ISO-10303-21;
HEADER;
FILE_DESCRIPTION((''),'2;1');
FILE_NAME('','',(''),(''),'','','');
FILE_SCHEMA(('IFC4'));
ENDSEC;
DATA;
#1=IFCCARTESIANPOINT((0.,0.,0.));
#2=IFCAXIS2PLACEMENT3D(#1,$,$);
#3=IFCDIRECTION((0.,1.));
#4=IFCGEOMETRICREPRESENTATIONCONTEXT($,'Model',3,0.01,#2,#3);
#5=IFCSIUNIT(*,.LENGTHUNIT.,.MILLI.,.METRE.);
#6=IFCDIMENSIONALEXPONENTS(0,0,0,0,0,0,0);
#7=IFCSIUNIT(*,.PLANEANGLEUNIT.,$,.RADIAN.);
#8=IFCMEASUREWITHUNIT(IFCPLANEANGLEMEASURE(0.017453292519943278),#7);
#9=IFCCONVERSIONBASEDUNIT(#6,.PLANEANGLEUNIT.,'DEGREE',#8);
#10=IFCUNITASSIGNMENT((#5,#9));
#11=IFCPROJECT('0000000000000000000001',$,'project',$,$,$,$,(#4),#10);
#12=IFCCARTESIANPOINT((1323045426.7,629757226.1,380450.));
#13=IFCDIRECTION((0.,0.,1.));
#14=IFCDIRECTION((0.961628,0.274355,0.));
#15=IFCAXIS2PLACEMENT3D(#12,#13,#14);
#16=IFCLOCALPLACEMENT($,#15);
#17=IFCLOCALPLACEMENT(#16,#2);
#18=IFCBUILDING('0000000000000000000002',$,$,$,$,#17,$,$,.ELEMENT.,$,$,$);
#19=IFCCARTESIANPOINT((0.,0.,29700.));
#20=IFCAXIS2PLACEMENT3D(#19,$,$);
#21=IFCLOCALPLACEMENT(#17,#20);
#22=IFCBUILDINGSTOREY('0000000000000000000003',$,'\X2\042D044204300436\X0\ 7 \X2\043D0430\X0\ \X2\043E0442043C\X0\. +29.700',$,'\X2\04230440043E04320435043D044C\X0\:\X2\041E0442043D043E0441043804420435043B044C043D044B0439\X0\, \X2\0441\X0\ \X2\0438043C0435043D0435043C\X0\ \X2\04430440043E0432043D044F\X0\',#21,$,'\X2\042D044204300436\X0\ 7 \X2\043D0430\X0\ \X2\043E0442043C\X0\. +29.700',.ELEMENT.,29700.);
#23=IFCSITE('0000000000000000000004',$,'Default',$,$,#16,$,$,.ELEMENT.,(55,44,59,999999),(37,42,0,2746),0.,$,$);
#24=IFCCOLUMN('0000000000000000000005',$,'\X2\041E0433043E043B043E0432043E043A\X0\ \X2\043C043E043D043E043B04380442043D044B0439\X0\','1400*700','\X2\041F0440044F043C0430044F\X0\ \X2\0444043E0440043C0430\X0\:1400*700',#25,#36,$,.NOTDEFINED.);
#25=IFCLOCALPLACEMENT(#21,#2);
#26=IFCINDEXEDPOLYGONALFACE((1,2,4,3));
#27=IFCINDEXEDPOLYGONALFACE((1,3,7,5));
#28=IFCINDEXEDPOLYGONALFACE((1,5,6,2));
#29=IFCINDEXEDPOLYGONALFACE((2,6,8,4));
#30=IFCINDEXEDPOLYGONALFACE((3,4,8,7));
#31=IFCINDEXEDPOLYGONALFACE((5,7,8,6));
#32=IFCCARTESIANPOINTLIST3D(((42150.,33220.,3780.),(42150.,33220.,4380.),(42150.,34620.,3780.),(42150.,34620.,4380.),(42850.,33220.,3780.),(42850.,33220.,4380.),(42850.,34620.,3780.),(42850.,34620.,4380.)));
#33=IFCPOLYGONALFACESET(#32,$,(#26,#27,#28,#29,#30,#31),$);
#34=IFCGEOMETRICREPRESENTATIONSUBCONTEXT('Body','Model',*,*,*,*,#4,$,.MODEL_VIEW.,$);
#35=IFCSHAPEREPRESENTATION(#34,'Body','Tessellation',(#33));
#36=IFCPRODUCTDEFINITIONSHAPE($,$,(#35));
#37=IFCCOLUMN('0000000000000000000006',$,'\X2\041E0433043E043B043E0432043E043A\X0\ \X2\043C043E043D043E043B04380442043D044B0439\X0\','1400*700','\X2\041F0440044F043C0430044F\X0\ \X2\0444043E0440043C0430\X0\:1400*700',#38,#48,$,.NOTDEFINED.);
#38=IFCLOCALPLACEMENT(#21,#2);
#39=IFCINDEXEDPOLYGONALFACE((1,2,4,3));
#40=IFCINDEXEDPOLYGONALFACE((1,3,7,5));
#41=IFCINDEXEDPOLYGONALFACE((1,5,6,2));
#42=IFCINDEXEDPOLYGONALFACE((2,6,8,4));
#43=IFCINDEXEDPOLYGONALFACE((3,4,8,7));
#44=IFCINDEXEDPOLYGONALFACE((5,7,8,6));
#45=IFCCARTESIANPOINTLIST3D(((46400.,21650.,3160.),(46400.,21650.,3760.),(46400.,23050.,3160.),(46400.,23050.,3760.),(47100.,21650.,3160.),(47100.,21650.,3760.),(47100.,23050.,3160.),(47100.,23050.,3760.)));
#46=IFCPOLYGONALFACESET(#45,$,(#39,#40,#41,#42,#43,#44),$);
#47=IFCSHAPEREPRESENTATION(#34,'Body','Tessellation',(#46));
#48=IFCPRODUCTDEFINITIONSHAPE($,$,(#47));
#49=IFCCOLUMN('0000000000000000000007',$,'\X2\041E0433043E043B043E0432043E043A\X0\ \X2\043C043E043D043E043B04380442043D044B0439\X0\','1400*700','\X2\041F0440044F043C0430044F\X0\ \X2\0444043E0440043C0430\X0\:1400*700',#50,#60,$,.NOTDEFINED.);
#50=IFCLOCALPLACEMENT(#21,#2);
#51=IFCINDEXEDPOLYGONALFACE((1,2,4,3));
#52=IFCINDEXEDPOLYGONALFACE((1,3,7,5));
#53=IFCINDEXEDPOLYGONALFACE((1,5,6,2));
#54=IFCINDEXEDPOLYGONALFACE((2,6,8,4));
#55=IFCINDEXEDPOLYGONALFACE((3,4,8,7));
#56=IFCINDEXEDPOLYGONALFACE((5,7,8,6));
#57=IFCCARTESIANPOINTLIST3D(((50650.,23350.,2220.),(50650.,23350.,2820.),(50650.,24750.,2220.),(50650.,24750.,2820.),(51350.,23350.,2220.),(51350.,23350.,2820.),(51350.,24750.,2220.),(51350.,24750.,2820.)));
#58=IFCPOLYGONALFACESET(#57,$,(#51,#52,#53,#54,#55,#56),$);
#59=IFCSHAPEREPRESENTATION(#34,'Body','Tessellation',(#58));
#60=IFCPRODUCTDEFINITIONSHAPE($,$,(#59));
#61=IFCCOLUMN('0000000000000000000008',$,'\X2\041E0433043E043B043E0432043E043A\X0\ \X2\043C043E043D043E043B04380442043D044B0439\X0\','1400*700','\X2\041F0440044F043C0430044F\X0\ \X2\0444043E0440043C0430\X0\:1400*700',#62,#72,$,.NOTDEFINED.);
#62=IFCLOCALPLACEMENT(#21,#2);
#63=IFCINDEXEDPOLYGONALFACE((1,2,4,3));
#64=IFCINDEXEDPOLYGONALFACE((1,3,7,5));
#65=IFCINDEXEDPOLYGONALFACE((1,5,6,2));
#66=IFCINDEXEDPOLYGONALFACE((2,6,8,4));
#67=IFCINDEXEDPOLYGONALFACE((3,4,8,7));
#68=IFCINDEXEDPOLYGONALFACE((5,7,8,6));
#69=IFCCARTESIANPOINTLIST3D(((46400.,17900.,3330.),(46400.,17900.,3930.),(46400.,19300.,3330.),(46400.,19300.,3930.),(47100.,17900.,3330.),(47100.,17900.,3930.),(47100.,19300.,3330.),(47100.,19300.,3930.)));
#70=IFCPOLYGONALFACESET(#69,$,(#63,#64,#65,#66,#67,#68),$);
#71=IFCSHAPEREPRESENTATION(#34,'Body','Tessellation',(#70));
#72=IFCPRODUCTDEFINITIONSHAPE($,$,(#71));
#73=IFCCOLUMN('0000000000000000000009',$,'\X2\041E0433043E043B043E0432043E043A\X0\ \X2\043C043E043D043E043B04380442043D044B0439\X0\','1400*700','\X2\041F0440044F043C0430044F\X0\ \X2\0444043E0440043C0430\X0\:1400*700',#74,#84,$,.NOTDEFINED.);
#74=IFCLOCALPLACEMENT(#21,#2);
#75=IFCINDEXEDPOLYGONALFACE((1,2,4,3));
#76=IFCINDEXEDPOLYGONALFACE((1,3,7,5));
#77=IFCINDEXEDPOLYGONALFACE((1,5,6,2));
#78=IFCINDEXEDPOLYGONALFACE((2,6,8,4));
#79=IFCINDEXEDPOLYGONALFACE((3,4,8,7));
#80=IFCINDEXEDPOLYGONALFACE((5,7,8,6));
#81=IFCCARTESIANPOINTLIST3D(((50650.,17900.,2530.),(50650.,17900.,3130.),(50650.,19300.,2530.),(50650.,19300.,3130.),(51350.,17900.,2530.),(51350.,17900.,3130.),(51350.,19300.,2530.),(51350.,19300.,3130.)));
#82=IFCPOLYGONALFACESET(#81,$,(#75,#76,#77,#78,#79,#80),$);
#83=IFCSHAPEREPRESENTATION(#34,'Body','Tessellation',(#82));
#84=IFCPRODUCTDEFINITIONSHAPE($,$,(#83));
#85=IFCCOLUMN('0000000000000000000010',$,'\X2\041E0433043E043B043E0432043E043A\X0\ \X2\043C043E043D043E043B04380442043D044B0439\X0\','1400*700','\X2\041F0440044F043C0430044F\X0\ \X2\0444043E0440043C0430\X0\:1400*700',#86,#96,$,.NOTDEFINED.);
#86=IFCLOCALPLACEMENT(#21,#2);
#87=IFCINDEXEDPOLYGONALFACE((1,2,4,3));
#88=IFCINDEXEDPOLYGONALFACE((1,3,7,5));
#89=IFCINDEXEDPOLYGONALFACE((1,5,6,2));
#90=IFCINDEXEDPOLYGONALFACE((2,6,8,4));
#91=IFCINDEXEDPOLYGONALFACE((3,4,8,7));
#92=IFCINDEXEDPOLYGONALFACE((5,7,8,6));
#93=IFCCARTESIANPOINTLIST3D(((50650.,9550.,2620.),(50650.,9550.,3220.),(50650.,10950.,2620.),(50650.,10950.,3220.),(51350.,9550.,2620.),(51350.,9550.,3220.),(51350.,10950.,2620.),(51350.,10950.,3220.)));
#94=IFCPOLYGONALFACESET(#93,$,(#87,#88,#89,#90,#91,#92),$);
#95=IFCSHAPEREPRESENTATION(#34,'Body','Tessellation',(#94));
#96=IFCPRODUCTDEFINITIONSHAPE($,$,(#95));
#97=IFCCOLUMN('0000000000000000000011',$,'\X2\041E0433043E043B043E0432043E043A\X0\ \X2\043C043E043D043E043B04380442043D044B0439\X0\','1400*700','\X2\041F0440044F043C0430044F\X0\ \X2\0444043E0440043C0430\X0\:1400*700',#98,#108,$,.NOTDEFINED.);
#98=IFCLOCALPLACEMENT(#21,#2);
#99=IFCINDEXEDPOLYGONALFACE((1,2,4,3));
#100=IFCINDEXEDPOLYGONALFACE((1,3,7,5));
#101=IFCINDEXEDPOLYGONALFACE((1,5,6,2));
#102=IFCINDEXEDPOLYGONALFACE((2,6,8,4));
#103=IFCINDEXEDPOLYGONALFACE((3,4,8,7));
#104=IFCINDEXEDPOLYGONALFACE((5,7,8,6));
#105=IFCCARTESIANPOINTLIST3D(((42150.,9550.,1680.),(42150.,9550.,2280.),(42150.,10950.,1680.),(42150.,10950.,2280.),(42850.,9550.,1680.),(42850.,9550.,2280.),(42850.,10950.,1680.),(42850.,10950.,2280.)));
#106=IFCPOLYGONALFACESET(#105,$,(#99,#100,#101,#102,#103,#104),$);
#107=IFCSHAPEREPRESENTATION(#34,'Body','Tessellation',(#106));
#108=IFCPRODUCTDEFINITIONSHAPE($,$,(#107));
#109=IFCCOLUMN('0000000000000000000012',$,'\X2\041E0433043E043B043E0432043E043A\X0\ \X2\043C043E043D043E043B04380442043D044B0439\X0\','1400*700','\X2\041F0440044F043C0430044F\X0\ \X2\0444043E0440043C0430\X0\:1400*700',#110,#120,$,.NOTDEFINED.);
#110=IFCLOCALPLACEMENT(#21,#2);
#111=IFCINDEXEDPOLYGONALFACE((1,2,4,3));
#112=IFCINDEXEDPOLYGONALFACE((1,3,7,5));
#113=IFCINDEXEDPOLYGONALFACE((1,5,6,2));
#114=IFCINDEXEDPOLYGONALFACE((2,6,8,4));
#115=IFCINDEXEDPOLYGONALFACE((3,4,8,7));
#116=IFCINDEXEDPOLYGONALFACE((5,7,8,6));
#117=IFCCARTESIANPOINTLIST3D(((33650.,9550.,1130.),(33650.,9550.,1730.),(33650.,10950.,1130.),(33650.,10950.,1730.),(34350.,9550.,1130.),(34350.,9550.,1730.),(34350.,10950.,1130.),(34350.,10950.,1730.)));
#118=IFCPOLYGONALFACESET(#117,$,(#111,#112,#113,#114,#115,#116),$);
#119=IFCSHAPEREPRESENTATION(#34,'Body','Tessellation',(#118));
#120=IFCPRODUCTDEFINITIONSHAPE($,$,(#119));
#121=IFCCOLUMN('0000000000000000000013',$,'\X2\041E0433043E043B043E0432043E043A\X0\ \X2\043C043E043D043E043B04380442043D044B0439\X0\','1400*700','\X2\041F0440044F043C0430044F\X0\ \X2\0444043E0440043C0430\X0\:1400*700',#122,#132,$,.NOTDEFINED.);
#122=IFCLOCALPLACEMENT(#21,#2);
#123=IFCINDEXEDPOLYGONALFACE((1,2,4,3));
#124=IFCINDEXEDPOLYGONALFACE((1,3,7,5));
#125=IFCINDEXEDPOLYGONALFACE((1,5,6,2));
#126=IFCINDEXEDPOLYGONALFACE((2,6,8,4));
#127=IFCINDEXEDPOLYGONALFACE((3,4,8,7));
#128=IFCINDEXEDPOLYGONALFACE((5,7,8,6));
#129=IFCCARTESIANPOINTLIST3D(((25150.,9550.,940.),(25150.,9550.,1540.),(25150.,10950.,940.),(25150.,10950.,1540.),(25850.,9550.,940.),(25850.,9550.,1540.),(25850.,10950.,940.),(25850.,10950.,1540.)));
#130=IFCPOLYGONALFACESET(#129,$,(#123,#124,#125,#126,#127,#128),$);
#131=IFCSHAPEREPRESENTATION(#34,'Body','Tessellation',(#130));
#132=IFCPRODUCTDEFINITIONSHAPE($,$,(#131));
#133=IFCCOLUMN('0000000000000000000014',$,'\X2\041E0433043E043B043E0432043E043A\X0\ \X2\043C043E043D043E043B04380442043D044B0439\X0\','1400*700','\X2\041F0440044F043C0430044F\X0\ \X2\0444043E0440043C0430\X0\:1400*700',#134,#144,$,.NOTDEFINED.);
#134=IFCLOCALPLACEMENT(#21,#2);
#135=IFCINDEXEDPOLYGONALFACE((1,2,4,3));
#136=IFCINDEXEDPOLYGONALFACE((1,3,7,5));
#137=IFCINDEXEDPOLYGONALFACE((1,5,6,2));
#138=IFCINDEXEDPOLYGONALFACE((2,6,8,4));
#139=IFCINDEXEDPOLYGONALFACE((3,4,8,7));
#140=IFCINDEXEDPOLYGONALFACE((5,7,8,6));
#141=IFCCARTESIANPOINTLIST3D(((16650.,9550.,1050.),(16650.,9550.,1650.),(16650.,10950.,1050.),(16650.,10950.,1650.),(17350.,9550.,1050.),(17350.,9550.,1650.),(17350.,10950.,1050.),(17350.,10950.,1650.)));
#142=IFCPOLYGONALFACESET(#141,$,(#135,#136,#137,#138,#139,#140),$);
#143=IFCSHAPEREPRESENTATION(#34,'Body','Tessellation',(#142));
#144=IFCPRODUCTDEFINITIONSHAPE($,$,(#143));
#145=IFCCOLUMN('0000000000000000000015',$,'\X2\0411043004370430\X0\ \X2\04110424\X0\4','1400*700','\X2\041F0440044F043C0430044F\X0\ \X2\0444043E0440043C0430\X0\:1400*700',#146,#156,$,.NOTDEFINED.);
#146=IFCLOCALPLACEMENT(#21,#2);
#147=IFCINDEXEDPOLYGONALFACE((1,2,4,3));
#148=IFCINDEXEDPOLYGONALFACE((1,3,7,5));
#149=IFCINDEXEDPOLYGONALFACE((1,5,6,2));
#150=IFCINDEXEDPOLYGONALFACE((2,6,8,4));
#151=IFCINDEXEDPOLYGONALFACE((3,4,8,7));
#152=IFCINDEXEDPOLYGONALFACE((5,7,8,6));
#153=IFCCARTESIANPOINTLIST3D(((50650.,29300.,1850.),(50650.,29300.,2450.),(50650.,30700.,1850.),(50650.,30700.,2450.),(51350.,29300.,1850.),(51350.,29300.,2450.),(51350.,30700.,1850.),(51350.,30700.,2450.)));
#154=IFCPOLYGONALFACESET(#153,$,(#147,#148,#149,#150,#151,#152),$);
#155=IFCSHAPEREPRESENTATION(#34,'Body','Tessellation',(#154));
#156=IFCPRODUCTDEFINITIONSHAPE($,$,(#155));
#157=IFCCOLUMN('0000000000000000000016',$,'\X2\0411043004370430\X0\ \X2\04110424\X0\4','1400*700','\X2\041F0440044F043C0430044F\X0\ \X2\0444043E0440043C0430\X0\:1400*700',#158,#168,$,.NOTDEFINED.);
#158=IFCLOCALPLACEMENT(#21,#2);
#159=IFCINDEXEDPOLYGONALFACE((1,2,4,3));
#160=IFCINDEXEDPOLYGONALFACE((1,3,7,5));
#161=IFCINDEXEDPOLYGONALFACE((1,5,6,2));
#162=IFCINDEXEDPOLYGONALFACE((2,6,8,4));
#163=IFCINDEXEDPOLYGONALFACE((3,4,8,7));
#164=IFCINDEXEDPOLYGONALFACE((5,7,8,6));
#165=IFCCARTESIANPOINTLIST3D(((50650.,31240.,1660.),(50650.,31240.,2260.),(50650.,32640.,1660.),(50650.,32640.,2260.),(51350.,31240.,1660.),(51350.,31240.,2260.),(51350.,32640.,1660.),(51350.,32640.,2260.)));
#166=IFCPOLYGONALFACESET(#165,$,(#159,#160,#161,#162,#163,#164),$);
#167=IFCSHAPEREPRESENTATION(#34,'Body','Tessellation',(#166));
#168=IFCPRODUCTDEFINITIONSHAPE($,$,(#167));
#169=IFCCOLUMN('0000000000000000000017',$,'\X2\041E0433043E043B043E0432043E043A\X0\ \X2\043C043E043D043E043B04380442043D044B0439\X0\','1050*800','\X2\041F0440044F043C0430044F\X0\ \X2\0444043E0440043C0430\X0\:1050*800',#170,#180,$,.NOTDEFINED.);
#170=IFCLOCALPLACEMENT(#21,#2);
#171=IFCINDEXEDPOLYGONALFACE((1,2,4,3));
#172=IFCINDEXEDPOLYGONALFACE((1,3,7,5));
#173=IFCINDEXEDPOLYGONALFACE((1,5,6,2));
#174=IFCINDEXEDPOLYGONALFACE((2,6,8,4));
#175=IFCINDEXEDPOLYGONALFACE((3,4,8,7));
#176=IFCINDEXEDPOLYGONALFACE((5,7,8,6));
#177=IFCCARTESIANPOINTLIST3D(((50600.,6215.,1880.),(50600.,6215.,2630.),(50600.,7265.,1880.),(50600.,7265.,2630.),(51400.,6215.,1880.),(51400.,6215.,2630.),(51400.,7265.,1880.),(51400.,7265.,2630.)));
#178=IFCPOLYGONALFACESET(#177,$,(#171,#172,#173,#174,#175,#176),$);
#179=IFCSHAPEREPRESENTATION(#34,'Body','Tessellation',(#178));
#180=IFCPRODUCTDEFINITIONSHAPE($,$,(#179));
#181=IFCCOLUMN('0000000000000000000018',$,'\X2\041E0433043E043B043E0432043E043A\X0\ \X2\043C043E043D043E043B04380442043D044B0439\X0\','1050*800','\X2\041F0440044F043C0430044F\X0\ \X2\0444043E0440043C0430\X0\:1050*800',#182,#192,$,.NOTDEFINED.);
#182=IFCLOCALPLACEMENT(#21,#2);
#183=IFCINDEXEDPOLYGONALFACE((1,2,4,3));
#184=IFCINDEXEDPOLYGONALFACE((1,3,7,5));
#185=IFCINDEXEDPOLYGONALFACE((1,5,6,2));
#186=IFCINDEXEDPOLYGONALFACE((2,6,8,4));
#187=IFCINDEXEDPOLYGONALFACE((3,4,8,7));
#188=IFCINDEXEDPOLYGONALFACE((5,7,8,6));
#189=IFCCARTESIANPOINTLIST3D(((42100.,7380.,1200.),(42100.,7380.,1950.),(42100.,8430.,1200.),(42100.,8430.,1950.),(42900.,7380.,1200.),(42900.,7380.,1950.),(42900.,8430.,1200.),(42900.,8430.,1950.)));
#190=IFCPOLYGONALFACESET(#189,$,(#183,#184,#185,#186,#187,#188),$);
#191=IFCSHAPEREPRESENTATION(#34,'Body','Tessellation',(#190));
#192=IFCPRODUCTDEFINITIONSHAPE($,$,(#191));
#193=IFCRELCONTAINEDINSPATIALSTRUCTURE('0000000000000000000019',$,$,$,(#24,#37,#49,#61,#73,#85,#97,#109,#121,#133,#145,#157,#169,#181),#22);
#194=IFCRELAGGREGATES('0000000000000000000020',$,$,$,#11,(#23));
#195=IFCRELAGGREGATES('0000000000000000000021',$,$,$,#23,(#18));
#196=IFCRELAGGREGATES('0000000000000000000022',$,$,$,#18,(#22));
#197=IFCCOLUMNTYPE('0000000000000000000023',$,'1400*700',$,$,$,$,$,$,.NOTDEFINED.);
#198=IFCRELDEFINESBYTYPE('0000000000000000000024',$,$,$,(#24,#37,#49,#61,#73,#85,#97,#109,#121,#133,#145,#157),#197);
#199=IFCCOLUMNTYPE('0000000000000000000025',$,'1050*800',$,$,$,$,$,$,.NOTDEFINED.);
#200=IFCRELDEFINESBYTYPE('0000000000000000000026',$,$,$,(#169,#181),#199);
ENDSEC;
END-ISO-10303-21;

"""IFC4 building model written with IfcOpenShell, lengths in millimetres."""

from ifc_helpers import new_model, entity, si_unit, converted_unit, direction, frame, origin, place, context, subcontext, project, spatial, indexed_curve, outline, extrude, type_object, element, save


model = new_model("IFC4")

# Units and contexts
model_context = context("Model", 3, precision=0.01, world=origin(), true_north=direction((0.0, 1.0)))
body_context = subcontext(model_context, "Body", "Model", "MODEL_VIEW")
ifc_project = project(units=[si_unit("LENGTHUNIT", "METRE", prefix="MILLI"), converted_unit("PLANEANGLEUNIT", "DEGREE", entity("IfcPlaneAngleMeasure", 0.017453292519943278), si_unit("PLANEANGLEUNIT", "RADIAN"), dimensions=[0, 0, 0, 0, 0, 0, 0])], contexts=[model_context])

# Site, building, storey
site_placement = place(None, frame((1323045426.7, 629757226.1, 380450.0), z_axis=(0.0, 0.0, 1.0), x_axis=(0.961628, 0.274355, 0.0)))
site = spatial("IfcSite", under=ifc_project, at=site_placement, Name="Default", CompositionType="ELEMENT", RefLatitude=(55, 44, 59, 999999), RefLongitude=(37, 42, 0, 2746), RefElevation=0.0)
building_placement = place(site_placement, origin())
building = spatial("IfcBuilding", under=site, at=building_placement, CompositionType="ELEMENT")
storey_placement = place(building_placement, frame((0.0, 0.0, 29700.0)))
storey = spatial("IfcBuildingStorey", under=building, at=storey_placement, Name="Этаж 7 на отм. +29.700", ObjectType="Уровень:Относительный, с именем уровня", LongName="Этаж 7 на отм. +29.700", CompositionType="ELEMENT", Elevation=29700.0)

# Columns
column_type_1 = type_object("IfcColumnType", Name="1400*700", PredefinedType="NOTDEFINED")
column_1_placement = place(storey_placement, origin())
element("IfcColumn", 1, at=column_1_placement, inside=storey, type_object=column_type_1, Name="Оголовок монолитный", Description="1400*700", ObjectType="Прямая форма:1400*700", PredefinedType="NOTDEFINED", context=body_context, shape_type="SweptSolid", body=[
    extrude(outline(indexed_curve([(-700.0, -350.0), (700.0, -350.0), (700.0, 350.0), (-700.0, 350.0), (-700.0, -350.0)], self_intersect=False)), frame((42500.0, 33920.0, 3780.0), z_axis=(0.0, 0.0, 1.0), x_axis=(0.0, -1.0, 0.0)), (0.0, 0.0, 1.0), 600.0),
])
column_2_placement = place(storey_placement, origin())
element("IfcColumn", 2, at=column_2_placement, inside=storey, type_object=column_type_1, Name="Оголовок монолитный", Description="1400*700", ObjectType="Прямая форма:1400*700", PredefinedType="NOTDEFINED", context=body_context, shape_type="SweptSolid", body=[
    extrude(outline(indexed_curve([(-700.0, -350.0), (700.0, -350.0), (700.0, 350.0), (-700.0, 350.0), (-700.0, -350.0)], self_intersect=False)), frame((46750.0, 22350.0, 3160.0), z_axis=(0.0, 0.0, 1.0), x_axis=(0.0, 1.0, 0.0)), (0.0, 0.0, 1.0), 600.0),
])
column_3_placement = place(storey_placement, origin())
element("IfcColumn", 3, at=column_3_placement, inside=storey, type_object=column_type_1, Name="Оголовок монолитный", Description="1400*700", ObjectType="Прямая форма:1400*700", PredefinedType="NOTDEFINED", context=body_context, shape_type="SweptSolid", body=[
    extrude(outline(indexed_curve([(-700.0, -350.0), (700.0, -350.0), (700.0, 350.0), (-700.0, 350.0), (-700.0, -350.0)], self_intersect=False)), frame((51000.0, 24050.0, 2220.0), z_axis=(0.0, 0.0, 1.0), x_axis=(0.0, 1.0, 0.0)), (0.0, 0.0, 1.0), 600.0),
])
column_4_placement = place(storey_placement, origin())
element("IfcColumn", 4, at=column_4_placement, inside=storey, type_object=column_type_1, Name="Оголовок монолитный", Description="1400*700", ObjectType="Прямая форма:1400*700", PredefinedType="NOTDEFINED", context=body_context, shape_type="SweptSolid", body=[
    extrude(outline(indexed_curve([(-700.0, -350.0), (700.0, -350.0), (700.0, 350.0), (-700.0, 350.0), (-700.0, -350.0)], self_intersect=False)), frame((46750.0, 18600.0, 3330.0), z_axis=(0.0, 0.0, 1.0), x_axis=(0.0, 1.0, 0.0)), (0.0, 0.0, 1.0), 600.0),
])
column_5_placement = place(storey_placement, origin())
element("IfcColumn", 5, at=column_5_placement, inside=storey, type_object=column_type_1, Name="Оголовок монолитный", Description="1400*700", ObjectType="Прямая форма:1400*700", PredefinedType="NOTDEFINED", context=body_context, shape_type="SweptSolid", body=[
    extrude(outline(indexed_curve([(-700.0, -350.0), (700.0, -350.0), (700.0, 350.0), (-700.0, 350.0), (-700.0, -350.0)], self_intersect=False)), frame((51000.0, 18600.0, 2530.0), z_axis=(0.0, 0.0, 1.0), x_axis=(0.0, 1.0, 0.0)), (0.0, 0.0, 1.0), 600.0),
])
column_6_placement = place(storey_placement, origin())
element("IfcColumn", 6, at=column_6_placement, inside=storey, type_object=column_type_1, Name="Оголовок монолитный", Description="1400*700", ObjectType="Прямая форма:1400*700", PredefinedType="NOTDEFINED", context=body_context, shape_type="SweptSolid", body=[
    extrude(outline(indexed_curve([(-700.0, -350.0), (700.0, -350.0), (700.0, 350.0), (-700.0, 350.0), (-700.0, -350.0)], self_intersect=False)), frame((51000.0, 10250.0, 2620.0), z_axis=(0.0, 0.0, 1.0), x_axis=(0.0, 1.0, 0.0)), (0.0, 0.0, 1.0), 600.0),
])
column_7_placement = place(storey_placement, origin())
element("IfcColumn", 7, at=column_7_placement, inside=storey, type_object=column_type_1, Name="Оголовок монолитный", Description="1400*700", ObjectType="Прямая форма:1400*700", PredefinedType="NOTDEFINED", context=body_context, shape_type="SweptSolid", body=[
    extrude(outline(indexed_curve([(-700.0, -350.0), (700.0, -350.0), (700.0, 350.0), (-700.0, 350.0), (-700.0, -350.0)], self_intersect=False)), frame((42500.0, 10250.0, 1680.0), z_axis=(0.0, 0.0, 1.0), x_axis=(0.0, 1.0, 0.0)), (0.0, 0.0, 1.0), 600.0),
])
column_8_placement = place(storey_placement, origin())
element("IfcColumn", 8, at=column_8_placement, inside=storey, type_object=column_type_1, Name="Оголовок монолитный", Description="1400*700", ObjectType="Прямая форма:1400*700", PredefinedType="NOTDEFINED", context=body_context, shape_type="SweptSolid", body=[
    extrude(outline(indexed_curve([(-700.0, -350.0), (700.0, -350.0), (700.0, 350.0), (-700.0, 350.0), (-700.0, -350.0)], self_intersect=False)), frame((34000.0, 10250.0, 1130.0), z_axis=(0.0, 0.0, 1.0), x_axis=(0.0, 1.0, 0.0)), (0.0, 0.0, 1.0), 600.0),
])
column_9_placement = place(storey_placement, origin())
element("IfcColumn", 9, at=column_9_placement, inside=storey, type_object=column_type_1, Name="Оголовок монолитный", Description="1400*700", ObjectType="Прямая форма:1400*700", PredefinedType="NOTDEFINED", context=body_context, shape_type="SweptSolid", body=[
    extrude(outline(indexed_curve([(-700.0, -350.0), (700.0, -350.0), (700.0, 350.0), (-700.0, 350.0), (-700.0, -350.0)], self_intersect=False)), frame((25500.0, 10250.0, 940.0), z_axis=(0.0, 0.0, 1.0), x_axis=(0.0, 1.0, 0.0)), (0.0, 0.0, 1.0), 600.0),
])
column_10_placement = place(storey_placement, origin())
element("IfcColumn", 10, at=column_10_placement, inside=storey, type_object=column_type_1, Name="Оголовок монолитный", Description="1400*700", ObjectType="Прямая форма:1400*700", PredefinedType="NOTDEFINED", context=body_context, shape_type="SweptSolid", body=[
    extrude(outline(indexed_curve([(-700.0, -350.0), (700.0, -350.0), (700.0, 350.0), (-700.0, 350.0), (-700.0, -350.0)], self_intersect=False)), frame((17000.0, 10250.0, 1050.0), z_axis=(0.0, 0.0, 1.0), x_axis=(0.0, 1.0, 0.0)), (0.0, 0.0, 1.0), 600.0),
])
column_11_placement = place(storey_placement, origin())
element("IfcColumn", 11, at=column_11_placement, inside=storey, type_object=column_type_1, Name="База БФ4", Description="1400*700", ObjectType="Прямая форма:1400*700", PredefinedType="NOTDEFINED", context=body_context, shape_type="SweptSolid", body=[
    extrude(outline(indexed_curve([(-700.0, -350.0), (700.0, -350.0), (700.0, 350.0), (-700.0, 350.0), (-700.0, -350.0)], self_intersect=False)), frame((51000.0, 30000.0, 1850.0), z_axis=(0.0, 0.0, 1.0), x_axis=(0.0, 1.0, 0.0)), (0.0, 0.0, 1.0), 600.0),
])
column_12_placement = place(storey_placement, origin())
element("IfcColumn", 12, at=column_12_placement, inside=storey, type_object=column_type_1, Name="База БФ4", Description="1400*700", ObjectType="Прямая форма:1400*700", PredefinedType="NOTDEFINED", context=body_context, shape_type="SweptSolid", body=[
    extrude(outline(indexed_curve([(-700.0, -350.0), (700.0, -350.0), (700.0, 350.0), (-700.0, 350.0), (-700.0, -350.0)], self_intersect=False)), frame((51000.0, 31940.0, 1660.0), z_axis=(0.0, 0.0, 1.0), x_axis=(0.0, 1.0, 0.0)), (0.0, 0.0, 1.0), 600.0),
])
column_type_2 = type_object("IfcColumnType", Name="1050*800", PredefinedType="NOTDEFINED")
column_13_placement = place(storey_placement, origin())
element("IfcColumn", 13, at=column_13_placement, inside=storey, type_object=column_type_2, Name="Оголовок монолитный", Description="1050*800", ObjectType="Прямая форма:1050*800", PredefinedType="NOTDEFINED", context=body_context, shape_type="SweptSolid", body=[
    extrude(outline(indexed_curve([(-525.0, -400.0), (525.0, -400.0), (525.0, 400.0), (-525.0, 400.0), (-525.0, -400.0)], self_intersect=False)), frame((51000.0, 6740.0, 1880.0), z_axis=(0.0, 0.0, 1.0), x_axis=(0.0, 1.0, 0.0)), (0.0, 0.0, 1.0), 750.0),
])
column_14_placement = place(storey_placement, origin())
element("IfcColumn", 14, at=column_14_placement, inside=storey, type_object=column_type_2, Name="Оголовок монолитный", Description="1050*800", ObjectType="Прямая форма:1050*800", PredefinedType="NOTDEFINED", context=body_context, shape_type="SweptSolid", body=[
    extrude(outline(indexed_curve([(-525.0, -400.0), (525.0, -400.0), (525.0, 400.0), (-525.0, 400.0), (-525.0, -400.0)], self_intersect=False)), frame((42500.0, 7905.0, 1200.0), z_axis=(0.0, 0.0, 1.0), x_axis=(0.0, 1.0, 0.0)), (0.0, 0.0, 1.0), 750.0),
])

save(model, "model.ifc")
